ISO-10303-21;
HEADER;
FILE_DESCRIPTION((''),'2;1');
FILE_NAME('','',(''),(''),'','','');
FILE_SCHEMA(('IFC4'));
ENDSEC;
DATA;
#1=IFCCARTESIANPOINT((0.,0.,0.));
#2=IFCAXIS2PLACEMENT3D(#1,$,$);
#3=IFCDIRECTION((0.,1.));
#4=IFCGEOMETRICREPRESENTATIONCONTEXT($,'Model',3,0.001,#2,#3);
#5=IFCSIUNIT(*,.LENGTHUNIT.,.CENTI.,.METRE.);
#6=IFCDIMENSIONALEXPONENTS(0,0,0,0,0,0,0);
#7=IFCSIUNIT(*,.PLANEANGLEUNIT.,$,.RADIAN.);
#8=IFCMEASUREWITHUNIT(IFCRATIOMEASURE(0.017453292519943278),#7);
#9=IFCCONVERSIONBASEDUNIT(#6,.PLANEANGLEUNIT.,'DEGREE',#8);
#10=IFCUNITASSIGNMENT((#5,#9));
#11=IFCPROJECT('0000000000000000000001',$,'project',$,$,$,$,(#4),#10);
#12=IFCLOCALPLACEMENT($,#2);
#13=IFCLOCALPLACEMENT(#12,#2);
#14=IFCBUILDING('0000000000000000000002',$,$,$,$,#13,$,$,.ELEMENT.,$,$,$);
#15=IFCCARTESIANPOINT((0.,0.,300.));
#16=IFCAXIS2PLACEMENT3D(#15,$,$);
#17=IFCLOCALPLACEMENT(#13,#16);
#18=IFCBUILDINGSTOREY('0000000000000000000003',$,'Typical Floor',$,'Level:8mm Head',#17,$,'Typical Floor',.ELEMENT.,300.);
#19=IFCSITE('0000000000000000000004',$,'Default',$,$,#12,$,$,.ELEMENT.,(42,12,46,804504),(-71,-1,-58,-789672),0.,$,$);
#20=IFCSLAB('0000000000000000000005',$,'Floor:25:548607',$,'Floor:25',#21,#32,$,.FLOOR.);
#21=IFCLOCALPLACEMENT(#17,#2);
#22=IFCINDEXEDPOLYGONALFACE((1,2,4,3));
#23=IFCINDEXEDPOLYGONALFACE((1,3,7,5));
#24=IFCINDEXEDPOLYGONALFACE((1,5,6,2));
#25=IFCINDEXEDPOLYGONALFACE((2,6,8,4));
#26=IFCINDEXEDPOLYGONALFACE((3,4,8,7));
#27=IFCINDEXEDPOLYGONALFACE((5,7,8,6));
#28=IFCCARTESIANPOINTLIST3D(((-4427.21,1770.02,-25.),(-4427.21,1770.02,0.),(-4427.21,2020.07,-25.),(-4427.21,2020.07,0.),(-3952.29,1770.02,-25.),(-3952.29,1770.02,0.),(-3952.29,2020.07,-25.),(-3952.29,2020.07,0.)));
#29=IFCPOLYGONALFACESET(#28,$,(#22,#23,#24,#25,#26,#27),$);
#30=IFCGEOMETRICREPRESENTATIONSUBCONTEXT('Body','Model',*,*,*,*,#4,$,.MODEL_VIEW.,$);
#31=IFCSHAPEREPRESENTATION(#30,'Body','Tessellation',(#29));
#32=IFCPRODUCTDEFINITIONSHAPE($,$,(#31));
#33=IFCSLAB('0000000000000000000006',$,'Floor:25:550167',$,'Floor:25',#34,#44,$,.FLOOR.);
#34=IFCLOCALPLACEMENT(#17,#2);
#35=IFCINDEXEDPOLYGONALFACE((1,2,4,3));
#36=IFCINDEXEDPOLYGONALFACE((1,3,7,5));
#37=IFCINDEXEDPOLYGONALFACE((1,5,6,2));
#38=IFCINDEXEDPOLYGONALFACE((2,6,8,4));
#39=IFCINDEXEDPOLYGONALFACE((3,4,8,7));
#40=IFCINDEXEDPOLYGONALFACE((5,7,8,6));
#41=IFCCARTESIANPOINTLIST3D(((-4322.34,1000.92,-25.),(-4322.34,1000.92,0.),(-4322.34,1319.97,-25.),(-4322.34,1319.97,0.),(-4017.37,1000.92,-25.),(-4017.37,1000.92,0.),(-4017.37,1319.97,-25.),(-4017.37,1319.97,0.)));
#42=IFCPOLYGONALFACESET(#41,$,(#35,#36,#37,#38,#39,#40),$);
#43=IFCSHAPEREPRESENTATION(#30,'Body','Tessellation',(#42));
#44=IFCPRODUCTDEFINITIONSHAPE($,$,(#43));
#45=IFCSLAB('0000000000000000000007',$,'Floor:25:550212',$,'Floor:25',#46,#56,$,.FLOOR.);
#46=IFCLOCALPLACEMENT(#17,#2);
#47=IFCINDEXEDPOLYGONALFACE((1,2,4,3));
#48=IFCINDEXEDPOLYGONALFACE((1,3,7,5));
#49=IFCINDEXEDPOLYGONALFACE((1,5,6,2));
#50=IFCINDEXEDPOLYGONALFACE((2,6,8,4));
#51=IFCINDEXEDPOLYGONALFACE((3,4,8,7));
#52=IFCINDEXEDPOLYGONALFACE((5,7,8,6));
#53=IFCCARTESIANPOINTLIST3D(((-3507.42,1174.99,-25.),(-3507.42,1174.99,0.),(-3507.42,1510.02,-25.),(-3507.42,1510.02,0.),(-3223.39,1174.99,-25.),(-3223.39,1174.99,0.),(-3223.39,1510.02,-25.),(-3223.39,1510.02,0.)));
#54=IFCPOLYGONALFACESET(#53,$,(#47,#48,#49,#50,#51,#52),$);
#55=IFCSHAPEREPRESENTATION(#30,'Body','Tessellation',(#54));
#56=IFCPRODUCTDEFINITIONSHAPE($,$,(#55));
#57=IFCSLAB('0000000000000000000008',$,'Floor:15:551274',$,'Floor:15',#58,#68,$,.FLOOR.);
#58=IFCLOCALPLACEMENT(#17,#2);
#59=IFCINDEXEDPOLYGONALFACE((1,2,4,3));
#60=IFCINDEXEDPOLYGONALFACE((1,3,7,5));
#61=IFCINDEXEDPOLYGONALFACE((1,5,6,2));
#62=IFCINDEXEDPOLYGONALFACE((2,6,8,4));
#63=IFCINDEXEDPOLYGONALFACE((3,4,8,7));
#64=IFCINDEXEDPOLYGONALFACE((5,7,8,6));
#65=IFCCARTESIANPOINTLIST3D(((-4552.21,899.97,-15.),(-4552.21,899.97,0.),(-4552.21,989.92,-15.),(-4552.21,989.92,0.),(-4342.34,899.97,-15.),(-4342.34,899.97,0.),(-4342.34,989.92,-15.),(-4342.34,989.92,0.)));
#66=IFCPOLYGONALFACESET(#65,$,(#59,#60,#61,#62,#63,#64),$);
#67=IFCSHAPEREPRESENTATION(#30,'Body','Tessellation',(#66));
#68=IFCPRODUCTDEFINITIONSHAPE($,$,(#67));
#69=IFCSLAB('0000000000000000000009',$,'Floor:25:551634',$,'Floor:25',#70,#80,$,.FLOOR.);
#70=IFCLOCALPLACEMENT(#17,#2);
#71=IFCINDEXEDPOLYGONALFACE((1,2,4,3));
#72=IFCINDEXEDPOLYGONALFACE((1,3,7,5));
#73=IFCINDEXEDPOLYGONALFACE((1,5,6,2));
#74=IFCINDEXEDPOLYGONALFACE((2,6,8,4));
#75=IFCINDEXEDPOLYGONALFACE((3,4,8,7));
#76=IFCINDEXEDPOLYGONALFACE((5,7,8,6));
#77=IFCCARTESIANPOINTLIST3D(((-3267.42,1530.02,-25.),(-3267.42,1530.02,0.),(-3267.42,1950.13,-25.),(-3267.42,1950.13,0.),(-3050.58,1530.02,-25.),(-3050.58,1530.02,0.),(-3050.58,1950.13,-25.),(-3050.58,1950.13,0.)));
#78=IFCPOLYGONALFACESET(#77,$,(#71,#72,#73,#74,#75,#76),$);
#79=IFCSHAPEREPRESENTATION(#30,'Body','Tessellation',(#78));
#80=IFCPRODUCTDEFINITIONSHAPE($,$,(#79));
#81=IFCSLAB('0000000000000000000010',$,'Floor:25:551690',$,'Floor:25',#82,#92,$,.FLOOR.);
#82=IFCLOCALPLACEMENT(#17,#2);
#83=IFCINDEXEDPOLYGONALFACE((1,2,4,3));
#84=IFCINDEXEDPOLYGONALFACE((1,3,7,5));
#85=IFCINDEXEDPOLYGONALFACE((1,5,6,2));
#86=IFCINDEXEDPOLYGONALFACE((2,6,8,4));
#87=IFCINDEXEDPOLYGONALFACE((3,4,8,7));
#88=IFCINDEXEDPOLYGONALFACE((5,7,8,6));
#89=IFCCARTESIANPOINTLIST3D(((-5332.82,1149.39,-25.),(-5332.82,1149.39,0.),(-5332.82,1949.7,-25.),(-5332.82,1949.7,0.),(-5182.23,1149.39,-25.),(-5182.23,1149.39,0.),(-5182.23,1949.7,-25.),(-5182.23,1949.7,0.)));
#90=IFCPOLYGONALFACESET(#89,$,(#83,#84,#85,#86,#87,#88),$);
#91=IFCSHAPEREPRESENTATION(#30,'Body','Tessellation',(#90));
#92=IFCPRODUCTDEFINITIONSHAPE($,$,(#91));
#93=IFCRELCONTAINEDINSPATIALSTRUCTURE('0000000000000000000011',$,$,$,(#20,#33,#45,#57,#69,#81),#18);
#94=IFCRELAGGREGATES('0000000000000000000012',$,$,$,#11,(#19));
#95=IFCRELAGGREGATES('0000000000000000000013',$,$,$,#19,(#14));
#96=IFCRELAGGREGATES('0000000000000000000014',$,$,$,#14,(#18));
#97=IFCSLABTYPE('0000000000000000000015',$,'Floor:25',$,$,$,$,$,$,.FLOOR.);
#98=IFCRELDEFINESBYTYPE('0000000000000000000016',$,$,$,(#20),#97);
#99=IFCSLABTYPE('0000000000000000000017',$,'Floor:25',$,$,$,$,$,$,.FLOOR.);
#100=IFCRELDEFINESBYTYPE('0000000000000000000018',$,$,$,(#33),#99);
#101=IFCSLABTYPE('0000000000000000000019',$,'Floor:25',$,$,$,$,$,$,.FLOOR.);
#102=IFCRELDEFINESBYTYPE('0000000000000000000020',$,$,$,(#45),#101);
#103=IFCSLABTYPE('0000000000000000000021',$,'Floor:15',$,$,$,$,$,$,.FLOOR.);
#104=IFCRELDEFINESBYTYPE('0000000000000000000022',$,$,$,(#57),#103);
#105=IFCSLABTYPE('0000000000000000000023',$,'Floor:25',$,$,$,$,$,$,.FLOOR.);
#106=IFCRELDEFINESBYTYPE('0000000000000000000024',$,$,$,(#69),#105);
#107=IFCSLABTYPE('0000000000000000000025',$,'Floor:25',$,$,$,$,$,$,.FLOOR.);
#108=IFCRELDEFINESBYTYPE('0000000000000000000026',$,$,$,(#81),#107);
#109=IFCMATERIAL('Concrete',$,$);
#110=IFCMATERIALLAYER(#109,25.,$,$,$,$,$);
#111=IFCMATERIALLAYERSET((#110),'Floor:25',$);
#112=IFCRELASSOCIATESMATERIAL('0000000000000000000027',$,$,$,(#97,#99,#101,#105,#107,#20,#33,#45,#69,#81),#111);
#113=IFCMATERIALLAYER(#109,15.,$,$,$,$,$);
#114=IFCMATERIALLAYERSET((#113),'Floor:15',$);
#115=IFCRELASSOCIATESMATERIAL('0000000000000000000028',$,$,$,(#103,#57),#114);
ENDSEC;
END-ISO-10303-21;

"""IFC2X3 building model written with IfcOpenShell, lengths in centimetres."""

from ifc_helpers import new_model, entity, si_unit, converted_unit, direction, frame, frame_2d, origin, origin_2d_with_axis, place, context, subcontext, project, spatial, rectangle, extrude, material, layer, layer_set, layer_usage, type_object, element, save


model = new_model("IFC2X3")

# Units and contexts
model_context = context("Model", 3, precision=0.001, world=origin(), true_north=direction((0.0, 1.0)))
body_context = subcontext(model_context, "Body", "Model", "MODEL_VIEW")
ifc_project = project(units=[si_unit("LENGTHUNIT", "METRE", prefix="CENTI"), converted_unit("PLANEANGLEUNIT", "DEGREE", entity("IfcRatioMeasure", 0.017453292519943278), si_unit("PLANEANGLEUNIT", "RADIAN"), dimensions=[0, 0, 0, 0, 0, 0, 0])], contexts=[model_context])

# Site, building, storey
site_placement = place(None, origin())
site = spatial("IfcSite", under=ifc_project, at=site_placement, Name="Default", CompositionType="ELEMENT", RefLatitude=(42, 12, 46, 804504), RefLongitude=(-71, -1, -58, -789672), RefElevation=0.0)
building_placement = place(site_placement, origin())
building = spatial("IfcBuilding", under=site, at=building_placement, CompositionType="ELEMENT")
storey_placement = place(building_placement, frame((0.0, 0.0, 300.0)))
storey = spatial("IfcBuildingStorey", under=building, at=storey_placement, Name="Typical Floor", ObjectType="Level:8mm Head", LongName="Typical Floor", CompositionType="ELEMENT", Elevation=300.0)

# Shared definitions
ifc_material = material(Name="Concrete")

# Slabs
ifc_layer_1 = layer(ifc_material, 25.0)
ifc_layer_set_1 = layer_set([ifc_layer_1], Name="Floor:25")
ifc_layer_usage_1 = layer_usage(ifc_layer_set_1, "AXIS3", "POSITIVE", 0.0)
slab_type_1 = type_object("IfcSlabType", Name="Floor:25", PredefinedType="FLOOR", material=ifc_layer_set_1)
slab_1_placement = place(storey_placement, origin())
element("IfcSlab", 1, at=slab_1_placement, inside=storey, type_object=slab_type_1, material=ifc_layer_usage_1, Name="Floor:25:548607", ObjectType="Floor:25", PredefinedType="FLOOR", context=body_context, shape_type="SweptSolid", body=[
    extrude(rectangle(XDim=250.05, YDim=474.92, at=origin_2d_with_axis()), frame((-4189.75, 1895.05, 0.0), z_axis=(0.0, 0.0, -1.0), x_axis=(0.0, 1.0, 0.0)), (0.0, 0.0, 1.0), 25.0),
])
ifc_layer_usage_2 = layer_usage(ifc_layer_set_1, "AXIS3", "POSITIVE", 0.0)
slab_type_2 = type_object("IfcSlabType", Name="Floor:25", PredefinedType="FLOOR", material=ifc_layer_set_1)
slab_2_placement = place(storey_placement, origin())
element("IfcSlab", 2, at=slab_2_placement, inside=storey, type_object=slab_type_2, material=ifc_layer_usage_2, Name="Floor:25:550167", ObjectType="Floor:25", PredefinedType="FLOOR", context=body_context, shape_type="SweptSolid", body=[
    extrude(rectangle(XDim=319.05, YDim=304.97, at=frame_2d((0.0, 0.0), x_axis=(1.0, 0.0))), frame((-4169.85, 1160.44, 0.0), z_axis=(0.0, 0.0, -1.0), x_axis=(0.0, 1.0, 0.0)), (0.0, 0.0, 1.0), 25.0),
])
ifc_layer_usage_3 = layer_usage(ifc_layer_set_1, "AXIS3", "POSITIVE", 0.0)
slab_type_3 = type_object("IfcSlabType", Name="Floor:25", PredefinedType="FLOOR", material=ifc_layer_set_1)
slab_3_placement = place(storey_placement, origin())
element("IfcSlab", 3, at=slab_3_placement, inside=storey, type_object=slab_type_3, material=ifc_layer_usage_3, Name="Floor:25:550212", ObjectType="Floor:25", PredefinedType="FLOOR", context=body_context, shape_type="SweptSolid", body=[
    extrude(rectangle(XDim=335.03, YDim=284.03, at=origin_2d_with_axis()), frame((-3365.41, 1342.51, 0.0), z_axis=(0.0, 0.0, -1.0), x_axis=(0.0, 1.0, 0.0)), (0.0, 0.0, 1.0), 25.0),
])
ifc_layer_2 = layer(ifc_material, 15.0)
ifc_layer_set_2 = layer_set([ifc_layer_2], Name="Floor:15")
ifc_layer_usage_4 = layer_usage(ifc_layer_set_2, "AXIS3", "POSITIVE", 0.0)
slab_type_4 = type_object("IfcSlabType", Name="Floor:15", PredefinedType="FLOOR", material=ifc_layer_set_2)
slab_4_placement = place(storey_placement, origin())
element("IfcSlab", 4, at=slab_4_placement, inside=storey, type_object=slab_type_4, material=ifc_layer_usage_4, Name="Floor:15:551274", ObjectType="Floor:15", PredefinedType="FLOOR", context=body_context, shape_type="SweptSolid", body=[
    extrude(rectangle(XDim=89.95, YDim=209.87, at=frame_2d((0.0, 0.0), x_axis=(1.0, 0.0))), frame((-4447.27, 944.94, 0.0), z_axis=(0.0, 0.0, -1.0), x_axis=(0.0, 1.0, 0.0)), (0.0, 0.0, 1.0), 15.0),
])
ifc_layer_usage_5 = layer_usage(ifc_layer_set_1, "AXIS3", "POSITIVE", 0.0)
slab_type_5 = type_object("IfcSlabType", Name="Floor:25", PredefinedType="FLOOR", material=ifc_layer_set_1)
slab_5_placement = place(storey_placement, origin())
element("IfcSlab", 5, at=slab_5_placement, inside=storey, type_object=slab_type_5, material=ifc_layer_usage_5, Name="Floor:25:551634", ObjectType="Floor:25", PredefinedType="FLOOR", context=body_context, shape_type="SweptSolid", body=[
    extrude(rectangle(XDim=420.11, YDim=216.84, at=origin_2d_with_axis()), frame((-3159.0, 1740.07, 0.0), z_axis=(0.0, 0.0, -1.0), x_axis=(0.0, 1.0, 0.0)), (0.0, 0.0, 1.0), 25.0),
])
ifc_layer_usage_6 = layer_usage(ifc_layer_set_1, "AXIS3", "POSITIVE", 0.0)
slab_type_6 = type_object("IfcSlabType", Name="Floor:25", PredefinedType="FLOOR", material=ifc_layer_set_1)
slab_6_placement = place(storey_placement, origin())
element("IfcSlab", 6, at=slab_6_placement, inside=storey, type_object=slab_type_6, material=ifc_layer_usage_6, Name="Floor:25:551690", ObjectType="Floor:25", PredefinedType="FLOOR", context=body_context, shape_type="SweptSolid", body=[
    extrude(rectangle(XDim=800.31, YDim=150.59, at=frame_2d((0.0, 0.0), x_axis=(1.0, 0.0))), frame((-5257.53, 1549.55, 0.0), z_axis=(0.0, 0.0, -1.0), x_axis=(0.0, 1.0, 0.0)), (0.0, 0.0, 1.0), 25.0),
])

save(model, "model.ifc")
